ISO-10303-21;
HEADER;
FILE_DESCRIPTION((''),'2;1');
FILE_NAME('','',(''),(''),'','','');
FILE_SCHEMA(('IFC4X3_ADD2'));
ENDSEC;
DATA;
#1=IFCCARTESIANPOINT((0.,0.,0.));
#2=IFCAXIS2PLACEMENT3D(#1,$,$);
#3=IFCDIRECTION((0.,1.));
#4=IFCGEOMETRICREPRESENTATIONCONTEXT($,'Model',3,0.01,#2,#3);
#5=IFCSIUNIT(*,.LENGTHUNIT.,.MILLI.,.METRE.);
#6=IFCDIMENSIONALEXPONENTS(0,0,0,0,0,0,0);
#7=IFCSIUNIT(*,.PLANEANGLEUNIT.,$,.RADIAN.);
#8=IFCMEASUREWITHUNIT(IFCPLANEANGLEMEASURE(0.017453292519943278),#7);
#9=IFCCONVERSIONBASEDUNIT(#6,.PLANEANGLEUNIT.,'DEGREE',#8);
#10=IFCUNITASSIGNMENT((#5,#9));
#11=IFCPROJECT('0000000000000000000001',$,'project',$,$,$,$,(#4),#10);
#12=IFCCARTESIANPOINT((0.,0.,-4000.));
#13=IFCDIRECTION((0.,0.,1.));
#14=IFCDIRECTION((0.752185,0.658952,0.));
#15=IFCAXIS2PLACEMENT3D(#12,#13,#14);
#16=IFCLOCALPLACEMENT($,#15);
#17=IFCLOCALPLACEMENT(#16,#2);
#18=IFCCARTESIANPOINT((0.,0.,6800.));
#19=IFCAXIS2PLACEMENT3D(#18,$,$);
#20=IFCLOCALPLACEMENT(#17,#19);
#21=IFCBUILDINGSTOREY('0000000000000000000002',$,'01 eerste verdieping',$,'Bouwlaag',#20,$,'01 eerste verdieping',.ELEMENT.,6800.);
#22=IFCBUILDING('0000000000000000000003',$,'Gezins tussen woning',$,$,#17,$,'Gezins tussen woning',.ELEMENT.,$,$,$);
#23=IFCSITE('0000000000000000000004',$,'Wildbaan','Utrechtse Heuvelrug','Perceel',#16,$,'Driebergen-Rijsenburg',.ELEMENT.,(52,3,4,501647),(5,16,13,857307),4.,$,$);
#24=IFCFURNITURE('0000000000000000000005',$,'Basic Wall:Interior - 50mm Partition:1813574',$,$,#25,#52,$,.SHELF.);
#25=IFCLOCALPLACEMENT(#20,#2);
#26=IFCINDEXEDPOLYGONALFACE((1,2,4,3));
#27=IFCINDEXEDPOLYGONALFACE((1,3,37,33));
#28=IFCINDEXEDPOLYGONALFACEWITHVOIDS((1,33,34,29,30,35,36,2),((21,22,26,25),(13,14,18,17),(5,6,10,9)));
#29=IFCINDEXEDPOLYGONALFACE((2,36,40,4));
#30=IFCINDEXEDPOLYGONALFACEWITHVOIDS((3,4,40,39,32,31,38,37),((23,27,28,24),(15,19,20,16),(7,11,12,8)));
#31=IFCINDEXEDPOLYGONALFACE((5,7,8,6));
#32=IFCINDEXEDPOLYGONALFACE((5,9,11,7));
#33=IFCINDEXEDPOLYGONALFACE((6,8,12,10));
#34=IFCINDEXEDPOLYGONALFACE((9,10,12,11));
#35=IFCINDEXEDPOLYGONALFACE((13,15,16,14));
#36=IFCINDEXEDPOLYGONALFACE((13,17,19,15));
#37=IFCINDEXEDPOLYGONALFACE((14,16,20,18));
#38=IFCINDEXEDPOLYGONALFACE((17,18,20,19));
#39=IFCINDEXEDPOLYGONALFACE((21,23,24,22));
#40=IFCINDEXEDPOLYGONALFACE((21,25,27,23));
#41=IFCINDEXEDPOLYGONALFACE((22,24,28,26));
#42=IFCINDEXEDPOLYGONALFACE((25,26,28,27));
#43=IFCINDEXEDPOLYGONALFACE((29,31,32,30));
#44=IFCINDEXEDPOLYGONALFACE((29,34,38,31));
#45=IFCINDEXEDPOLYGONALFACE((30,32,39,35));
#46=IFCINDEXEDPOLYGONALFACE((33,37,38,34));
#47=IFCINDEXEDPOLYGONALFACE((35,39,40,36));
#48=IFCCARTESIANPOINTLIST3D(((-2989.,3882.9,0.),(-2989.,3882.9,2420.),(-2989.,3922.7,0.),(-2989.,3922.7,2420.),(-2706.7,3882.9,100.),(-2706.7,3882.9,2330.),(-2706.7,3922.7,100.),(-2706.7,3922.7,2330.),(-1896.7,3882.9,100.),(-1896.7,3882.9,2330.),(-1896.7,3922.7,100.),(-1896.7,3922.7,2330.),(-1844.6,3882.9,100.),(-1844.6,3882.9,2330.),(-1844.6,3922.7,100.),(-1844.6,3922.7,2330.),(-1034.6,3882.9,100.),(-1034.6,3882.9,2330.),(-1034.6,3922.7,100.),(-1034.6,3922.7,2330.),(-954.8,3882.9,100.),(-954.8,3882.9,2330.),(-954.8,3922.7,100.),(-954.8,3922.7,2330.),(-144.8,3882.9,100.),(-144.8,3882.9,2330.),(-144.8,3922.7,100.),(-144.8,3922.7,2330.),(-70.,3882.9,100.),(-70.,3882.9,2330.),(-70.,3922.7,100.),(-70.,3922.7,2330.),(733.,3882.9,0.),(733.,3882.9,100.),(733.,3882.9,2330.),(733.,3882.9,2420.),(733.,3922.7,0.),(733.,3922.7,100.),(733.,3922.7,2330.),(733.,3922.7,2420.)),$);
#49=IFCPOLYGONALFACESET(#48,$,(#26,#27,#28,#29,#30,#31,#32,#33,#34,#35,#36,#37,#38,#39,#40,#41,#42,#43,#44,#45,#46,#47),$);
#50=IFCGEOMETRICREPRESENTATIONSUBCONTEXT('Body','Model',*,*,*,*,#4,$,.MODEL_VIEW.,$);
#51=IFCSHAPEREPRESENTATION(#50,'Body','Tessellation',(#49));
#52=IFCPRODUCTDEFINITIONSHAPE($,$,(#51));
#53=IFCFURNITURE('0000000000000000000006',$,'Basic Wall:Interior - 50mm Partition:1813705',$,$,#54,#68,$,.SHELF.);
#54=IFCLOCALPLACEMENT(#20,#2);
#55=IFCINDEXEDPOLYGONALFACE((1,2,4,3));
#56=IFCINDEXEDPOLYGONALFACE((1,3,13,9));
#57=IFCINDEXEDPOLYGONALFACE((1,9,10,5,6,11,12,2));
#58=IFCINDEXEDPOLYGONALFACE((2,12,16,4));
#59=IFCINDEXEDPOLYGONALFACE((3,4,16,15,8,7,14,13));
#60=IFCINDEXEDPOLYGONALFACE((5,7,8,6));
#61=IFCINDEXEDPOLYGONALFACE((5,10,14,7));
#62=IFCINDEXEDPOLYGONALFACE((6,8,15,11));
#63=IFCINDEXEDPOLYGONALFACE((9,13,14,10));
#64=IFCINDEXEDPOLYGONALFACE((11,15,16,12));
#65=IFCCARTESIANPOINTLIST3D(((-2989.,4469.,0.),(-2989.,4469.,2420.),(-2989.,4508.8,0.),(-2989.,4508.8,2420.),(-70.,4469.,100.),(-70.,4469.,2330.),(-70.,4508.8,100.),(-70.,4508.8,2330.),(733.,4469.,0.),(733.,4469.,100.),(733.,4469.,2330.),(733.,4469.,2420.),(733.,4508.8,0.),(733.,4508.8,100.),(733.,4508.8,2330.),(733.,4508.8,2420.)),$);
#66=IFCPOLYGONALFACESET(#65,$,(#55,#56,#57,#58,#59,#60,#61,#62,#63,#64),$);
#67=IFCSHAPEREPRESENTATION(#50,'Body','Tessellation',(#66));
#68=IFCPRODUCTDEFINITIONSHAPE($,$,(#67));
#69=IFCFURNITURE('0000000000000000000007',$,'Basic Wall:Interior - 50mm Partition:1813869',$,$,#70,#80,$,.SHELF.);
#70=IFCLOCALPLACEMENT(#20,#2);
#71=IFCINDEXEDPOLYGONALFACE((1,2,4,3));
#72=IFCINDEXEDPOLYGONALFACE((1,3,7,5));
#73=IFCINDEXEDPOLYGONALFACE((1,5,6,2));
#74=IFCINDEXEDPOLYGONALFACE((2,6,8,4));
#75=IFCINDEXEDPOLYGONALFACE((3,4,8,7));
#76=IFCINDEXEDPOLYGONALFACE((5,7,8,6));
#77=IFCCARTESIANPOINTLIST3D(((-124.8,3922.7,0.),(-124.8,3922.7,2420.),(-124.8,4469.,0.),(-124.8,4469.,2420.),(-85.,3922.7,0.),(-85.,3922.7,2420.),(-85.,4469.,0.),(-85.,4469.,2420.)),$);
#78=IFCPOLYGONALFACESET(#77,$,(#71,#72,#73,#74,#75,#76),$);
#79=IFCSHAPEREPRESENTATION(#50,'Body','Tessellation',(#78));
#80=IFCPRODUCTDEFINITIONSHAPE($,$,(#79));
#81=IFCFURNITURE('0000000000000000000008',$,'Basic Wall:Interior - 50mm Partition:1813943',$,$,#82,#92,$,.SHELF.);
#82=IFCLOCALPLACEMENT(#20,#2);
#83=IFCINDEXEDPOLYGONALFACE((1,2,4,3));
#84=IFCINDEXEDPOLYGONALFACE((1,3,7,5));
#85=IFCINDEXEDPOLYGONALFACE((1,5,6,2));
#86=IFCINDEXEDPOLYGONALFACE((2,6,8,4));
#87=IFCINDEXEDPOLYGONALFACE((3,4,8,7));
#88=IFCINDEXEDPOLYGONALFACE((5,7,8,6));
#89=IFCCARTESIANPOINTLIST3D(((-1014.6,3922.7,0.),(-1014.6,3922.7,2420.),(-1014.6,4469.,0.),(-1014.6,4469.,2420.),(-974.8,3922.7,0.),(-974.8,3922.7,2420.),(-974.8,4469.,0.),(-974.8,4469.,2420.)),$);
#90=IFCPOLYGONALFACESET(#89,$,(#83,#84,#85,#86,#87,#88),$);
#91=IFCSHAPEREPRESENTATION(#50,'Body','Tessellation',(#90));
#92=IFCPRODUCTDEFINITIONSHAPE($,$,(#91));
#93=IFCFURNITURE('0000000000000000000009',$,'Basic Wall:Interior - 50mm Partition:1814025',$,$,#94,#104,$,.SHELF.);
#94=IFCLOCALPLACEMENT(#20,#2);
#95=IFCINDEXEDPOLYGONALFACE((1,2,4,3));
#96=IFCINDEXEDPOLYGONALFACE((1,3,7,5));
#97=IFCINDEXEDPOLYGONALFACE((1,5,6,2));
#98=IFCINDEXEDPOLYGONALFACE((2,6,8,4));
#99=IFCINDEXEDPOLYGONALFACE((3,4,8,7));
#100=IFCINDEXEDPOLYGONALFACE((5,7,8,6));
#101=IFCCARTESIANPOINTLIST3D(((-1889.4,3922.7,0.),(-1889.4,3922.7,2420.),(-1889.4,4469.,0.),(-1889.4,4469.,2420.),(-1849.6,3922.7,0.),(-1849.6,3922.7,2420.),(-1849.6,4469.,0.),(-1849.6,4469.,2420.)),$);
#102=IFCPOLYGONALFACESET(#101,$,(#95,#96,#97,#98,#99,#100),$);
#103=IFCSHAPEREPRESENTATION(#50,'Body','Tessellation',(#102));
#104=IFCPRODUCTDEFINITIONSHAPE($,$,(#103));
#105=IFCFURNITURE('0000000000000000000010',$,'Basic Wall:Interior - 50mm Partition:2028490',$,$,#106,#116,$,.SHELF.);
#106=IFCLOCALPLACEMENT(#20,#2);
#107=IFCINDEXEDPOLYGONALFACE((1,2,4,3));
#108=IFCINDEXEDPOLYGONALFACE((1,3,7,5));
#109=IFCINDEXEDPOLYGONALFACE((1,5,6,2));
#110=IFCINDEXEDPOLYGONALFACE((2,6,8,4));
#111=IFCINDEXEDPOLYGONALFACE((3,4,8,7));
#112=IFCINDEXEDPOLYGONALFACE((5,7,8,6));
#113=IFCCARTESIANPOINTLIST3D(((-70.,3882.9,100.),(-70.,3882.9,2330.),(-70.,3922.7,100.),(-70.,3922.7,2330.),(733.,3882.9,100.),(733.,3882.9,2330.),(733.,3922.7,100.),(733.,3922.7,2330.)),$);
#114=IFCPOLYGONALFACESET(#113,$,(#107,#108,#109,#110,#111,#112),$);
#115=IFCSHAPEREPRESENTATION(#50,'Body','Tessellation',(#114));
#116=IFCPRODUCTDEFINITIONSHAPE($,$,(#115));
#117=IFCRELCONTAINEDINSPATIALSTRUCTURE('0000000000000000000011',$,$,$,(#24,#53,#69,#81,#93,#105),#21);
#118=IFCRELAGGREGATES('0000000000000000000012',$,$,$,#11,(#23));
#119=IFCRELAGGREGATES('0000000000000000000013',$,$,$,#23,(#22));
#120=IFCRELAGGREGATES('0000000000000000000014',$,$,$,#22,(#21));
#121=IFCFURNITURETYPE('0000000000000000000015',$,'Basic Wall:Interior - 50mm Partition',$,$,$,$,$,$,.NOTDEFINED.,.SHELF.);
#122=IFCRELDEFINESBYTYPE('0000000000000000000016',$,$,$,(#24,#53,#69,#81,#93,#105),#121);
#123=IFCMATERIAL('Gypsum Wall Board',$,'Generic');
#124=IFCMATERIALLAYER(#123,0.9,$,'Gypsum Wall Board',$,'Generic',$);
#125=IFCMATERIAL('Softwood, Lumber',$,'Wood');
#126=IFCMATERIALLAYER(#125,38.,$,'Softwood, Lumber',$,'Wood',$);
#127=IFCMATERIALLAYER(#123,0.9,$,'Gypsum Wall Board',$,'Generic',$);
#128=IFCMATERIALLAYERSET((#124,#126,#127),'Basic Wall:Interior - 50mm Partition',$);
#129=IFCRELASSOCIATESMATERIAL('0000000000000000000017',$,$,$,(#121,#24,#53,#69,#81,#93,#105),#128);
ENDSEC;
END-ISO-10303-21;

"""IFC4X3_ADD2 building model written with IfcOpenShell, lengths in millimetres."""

from ifc_helpers import new_model, entity, si_unit, converted_unit, direction, frame, frame_2d, origin, origin_2d_with_axis, place, context, subcontext, project, spatial, rectangle, extrude, material, layer, layer_set, layer_usage, type_object, element, save


model = new_model("IFC4X3_ADD2")

# Units and contexts
model_context = context("Model", 3, precision=0.01, world=origin(), true_north=direction((0.0, 1.0)))
body_context = subcontext(model_context, "Body", "Model", "MODEL_VIEW")
ifc_project = project(units=[si_unit("LENGTHUNIT", "METRE", prefix="MILLI"), converted_unit("PLANEANGLEUNIT", "DEGREE", entity("IfcPlaneAngleMeasure", 0.017453292519943278), si_unit("PLANEANGLEUNIT", "RADIAN"), dimensions=[0, 0, 0, 0, 0, 0, 0])], contexts=[model_context])

# Site, building, storey
site_placement = place(None, frame((0.0, 0.0, -4000.0), z_axis=(0.0, 0.0, 1.0), x_axis=(0.752185, 0.658952, 0.0)))
site = spatial("IfcSite", under=ifc_project, at=site_placement, Name="Wildbaan", Description="Utrechtse Heuvelrug", ObjectType="Perceel", LongName="Driebergen-Rijsenburg", CompositionType="ELEMENT", RefLatitude=(52, 3, 4, 501647), RefLongitude=(5, 16, 13, 857307), RefElevation=4.0)
building_placement = place(site_placement, origin())
building = spatial("IfcBuilding", under=site, at=building_placement, Name="Gezins tussen woning", LongName="Gezins tussen woning", CompositionType="ELEMENT")
storey_placement = place(building_placement, frame((0.0, 0.0, 6800.0)))
storey = spatial("IfcBuildingStorey", under=building, at=storey_placement, Name="01 eerste verdieping", ObjectType="Bouwlaag", LongName="01 eerste verdieping", CompositionType="ELEMENT", Elevation=6800.0)

# Shared definitions
ifc_material_1 = material(Name="Gypsum Wall Board", Category="Generic")
ifc_material_2 = material(Name="Softwood, Lumber", Category="Wood")

# Furniture, openings
ifc_layer_1 = layer(ifc_material_1, 0.9, Name="Gypsum Wall Board", Category="Generic")
ifc_layer_2 = layer(ifc_material_2, 38.0, Name="Softwood, Lumber", Category="Wood")
ifc_layer_3 = layer(ifc_material_1, 0.9, Name="Gypsum Wall Board", Category="Generic")
ifc_layer_set_1 = layer_set([ifc_layer_1, ifc_layer_2, ifc_layer_3], Name="Basic Wall:Interior - 50mm Partition")
ifc_layer_usage_1 = layer_usage(ifc_layer_set_1, "AXIS2", "NEGATIVE", 19.9)
furniture_type = type_object("IfcFurnitureType", Name="Basic Wall:Interior - 50mm Partition", PredefinedType="SHELF", material=ifc_layer_set_1)
furniture_1_placement = place(storey_placement, frame((733.0, 3902.8, 0.0), z_axis=(0.0, 0.0, 1.0), x_axis=(-1.0, 0.0, 0.0)))
furniture_1 = element("IfcFurniture", 1, at=furniture_1_placement, inside=storey, type_object=furniture_type, material=ifc_layer_usage_1, Name="Basic Wall:Interior - 50mm Partition:1813574", PredefinedType="SHELF", context=body_context, shape_type="SweptSolid", body=[
    extrude(rectangle(XDim=3722.0, YDim=39.8, at=frame_2d((1861.0, 0.0), x_axis=(-1.0, 0.0))), origin(), (0.0, 0.0, 1.0), 2420.0),
])
opening_1_placement = place(furniture_1_placement, frame((733.0, 3902.8, 100.0), z_axis=(0.0, 0.0, 1.0), x_axis=(-1.0, 0.0, 0.0)))
element("IfcOpeningElement", 2, at=opening_1_placement, cuts=furniture_1, PredefinedType="OPENING", context=body_context, shape_type="SweptSolid", body=[
    extrude(rectangle(XDim=2230.0, YDim=810.0, at=origin_2d_with_axis()), frame((335.0, 5446.7, 1115.0), z_axis=(0.0, -1.0, 0.0), x_axis=(0.0, 0.0, 1.0)), (0.0, 0.0, 1.0), 3048.0),
])
opening_2_placement = place(furniture_1_placement, frame((877.8, -19.9, 100.0)))
element("IfcOpeningElement", 3, at=opening_2_placement, cuts=furniture_1, PredefinedType="OPENING", context=body_context, shape_type="SweptSolid", body=[
    extrude(rectangle(XDim=2230.0, YDim=810.0, at=frame_2d((1115.0, 405.0), x_axis=(1.0, 0.0))), frame((0.0, 0.0, 0.0), z_axis=(0.0, 1.0, 0.0), x_axis=(0.0, 0.0, 1.0)), (0.0, 0.0, 1.0), 39.8),
])
opening_3_placement = place(furniture_1_placement, frame((2629.7, -19.9, 100.0)))
element("IfcOpeningElement", 4, at=opening_3_placement, cuts=furniture_1, PredefinedType="OPENING", context=body_context, shape_type="SweptSolid", body=[
    extrude(rectangle(XDim=2230.0, YDim=810.0, at=frame_2d((1115.0, 405.0), x_axis=(1.0, 0.0))), frame((0.0, 0.0, 0.0), z_axis=(0.0, 1.0, 0.0), x_axis=(0.0, 0.0, 1.0)), (0.0, 0.0, 1.0), 39.8),
])
opening_4_placement = place(furniture_1_placement, frame((1767.6, -19.9, 100.0)))
element("IfcOpeningElement", 5, at=opening_4_placement, cuts=furniture_1, PredefinedType="OPENING", context=body_context, shape_type="SweptSolid", body=[
    extrude(rectangle(XDim=2230.0, YDim=810.0, at=frame_2d((1115.0, 405.0), x_axis=(1.0, 0.0))), frame((0.0, 0.0, 0.0), z_axis=(0.0, 1.0, 0.0), x_axis=(0.0, 0.0, 1.0)), (0.0, 0.0, 1.0), 39.8),
])

# Furniture, opening
ifc_layer_usage_2 = layer_usage(ifc_layer_set_1, "AXIS2", "NEGATIVE", 19.9)
furniture_2_placement = place(storey_placement, frame((733.0, 4488.9, 0.0), z_axis=(0.0, 0.0, 1.0), x_axis=(-1.0, 0.0, 0.0)))
furniture_2 = element("IfcFurniture", 6, at=furniture_2_placement, inside=storey, type_object=furniture_type, material=ifc_layer_usage_2, Name="Basic Wall:Interior - 50mm Partition:1813705", PredefinedType="SHELF", context=body_context, shape_type="SweptSolid", body=[
    extrude(rectangle(XDim=3722.0, YDim=39.8, at=frame_2d((1861.0, 0.0), x_axis=(-1.0, 0.0))), origin(), (0.0, 0.0, 1.0), 2420.0),
])
opening_5_placement = place(furniture_2_placement, frame((803.0, 19.9, 100.0)))
element("IfcOpeningElement", 7, at=opening_5_placement, cuts=furniture_2, PredefinedType="OPENING", context=body_context, shape_type="SweptSolid", body=[
    extrude(rectangle(XDim=2230.0, YDim=810.0, at=frame_2d((1115.0, 405.0), x_axis=(1.0, 0.0))), frame((0.0, 0.0, 0.0), z_axis=(0.0, -1.0, 0.0), x_axis=(0.0, 0.0, 1.0)), (0.0, 0.0, 1.0), 39.8),
])

# Furniture
ifc_layer_usage_3 = layer_usage(ifc_layer_set_1, "AXIS2", "NEGATIVE", 19.9)
furniture_3_placement = place(storey_placement, frame((-104.9, 4469.0, 0.0), z_axis=(0.0, 0.0, 1.0), x_axis=(0.0, -1.0, 0.0)))
element("IfcFurniture", 8, at=furniture_3_placement, inside=storey, type_object=furniture_type, material=ifc_layer_usage_3, Name="Basic Wall:Interior - 50mm Partition:1813869", PredefinedType="SHELF", context=body_context, shape_type="SweptSolid", body=[
    extrude(rectangle(XDim=546.3, YDim=39.8, at=frame_2d((273.1, 0.0), x_axis=(-1.0, 0.0))), origin(), (0.0, 0.0, 1.0), 2420.0),
])
ifc_layer_usage_4 = layer_usage(ifc_layer_set_1, "AXIS2", "NEGATIVE", 19.9)
furniture_4_placement = place(storey_placement, frame((-994.7, 4469.0, 0.0), z_axis=(0.0, 0.0, 1.0), x_axis=(0.0, -1.0, 0.0)))
element("IfcFurniture", 9, at=furniture_4_placement, inside=storey, type_object=furniture_type, material=ifc_layer_usage_4, Name="Basic Wall:Interior - 50mm Partition:1813943", PredefinedType="SHELF", context=body_context, shape_type="SweptSolid", body=[
    extrude(rectangle(XDim=546.3, YDim=39.8, at=frame_2d((273.1, 0.0), x_axis=(-1.0, 0.0))), origin(), (0.0, 0.0, 1.0), 2420.0),
])
ifc_layer_usage_5 = layer_usage(ifc_layer_set_1, "AXIS2", "NEGATIVE", 19.9)
furniture_5_placement = place(storey_placement, frame((-1869.5, 4469.0, 0.0), z_axis=(0.0, 0.0, 1.0), x_axis=(0.0, -1.0, 0.0)))
element("IfcFurniture", 10, at=furniture_5_placement, inside=storey, type_object=furniture_type, material=ifc_layer_usage_5, Name="Basic Wall:Interior - 50mm Partition:1814025", PredefinedType="SHELF", context=body_context, shape_type="SweptSolid", body=[
    extrude(rectangle(XDim=546.3, YDim=39.8, at=frame_2d((273.1, 0.0), x_axis=(-1.0, 0.0))), origin(), (0.0, 0.0, 1.0), 2420.0),
])
ifc_layer_usage_6 = layer_usage(ifc_layer_set_1, "AXIS2", "NEGATIVE", 19.9)
furniture_6_placement = place(storey_placement, frame((733.0, 3902.8, 100.0), z_axis=(0.0, 0.0, 1.0), x_axis=(-1.0, 0.0, 0.0)))
element("IfcFurniture", 11, at=furniture_6_placement, inside=storey, type_object=furniture_type, material=ifc_layer_usage_6, Name="Basic Wall:Interior - 50mm Partition:2028490", PredefinedType="SHELF", context=body_context, shape_type="SweptSolid", body=[
    extrude(rectangle(XDim=803.0, YDim=39.8, at=frame_2d((0.0, 0.0), x_axis=(1.0, 0.0))), frame((401.5, 0.0, 0.0), z_axis=(0.0, 0.0, 1.0), x_axis=(-1.0, 0.0, 0.0)), (0.0, 0.0, 1.0), 2230.0),
])

save(model, "model.ifc")
